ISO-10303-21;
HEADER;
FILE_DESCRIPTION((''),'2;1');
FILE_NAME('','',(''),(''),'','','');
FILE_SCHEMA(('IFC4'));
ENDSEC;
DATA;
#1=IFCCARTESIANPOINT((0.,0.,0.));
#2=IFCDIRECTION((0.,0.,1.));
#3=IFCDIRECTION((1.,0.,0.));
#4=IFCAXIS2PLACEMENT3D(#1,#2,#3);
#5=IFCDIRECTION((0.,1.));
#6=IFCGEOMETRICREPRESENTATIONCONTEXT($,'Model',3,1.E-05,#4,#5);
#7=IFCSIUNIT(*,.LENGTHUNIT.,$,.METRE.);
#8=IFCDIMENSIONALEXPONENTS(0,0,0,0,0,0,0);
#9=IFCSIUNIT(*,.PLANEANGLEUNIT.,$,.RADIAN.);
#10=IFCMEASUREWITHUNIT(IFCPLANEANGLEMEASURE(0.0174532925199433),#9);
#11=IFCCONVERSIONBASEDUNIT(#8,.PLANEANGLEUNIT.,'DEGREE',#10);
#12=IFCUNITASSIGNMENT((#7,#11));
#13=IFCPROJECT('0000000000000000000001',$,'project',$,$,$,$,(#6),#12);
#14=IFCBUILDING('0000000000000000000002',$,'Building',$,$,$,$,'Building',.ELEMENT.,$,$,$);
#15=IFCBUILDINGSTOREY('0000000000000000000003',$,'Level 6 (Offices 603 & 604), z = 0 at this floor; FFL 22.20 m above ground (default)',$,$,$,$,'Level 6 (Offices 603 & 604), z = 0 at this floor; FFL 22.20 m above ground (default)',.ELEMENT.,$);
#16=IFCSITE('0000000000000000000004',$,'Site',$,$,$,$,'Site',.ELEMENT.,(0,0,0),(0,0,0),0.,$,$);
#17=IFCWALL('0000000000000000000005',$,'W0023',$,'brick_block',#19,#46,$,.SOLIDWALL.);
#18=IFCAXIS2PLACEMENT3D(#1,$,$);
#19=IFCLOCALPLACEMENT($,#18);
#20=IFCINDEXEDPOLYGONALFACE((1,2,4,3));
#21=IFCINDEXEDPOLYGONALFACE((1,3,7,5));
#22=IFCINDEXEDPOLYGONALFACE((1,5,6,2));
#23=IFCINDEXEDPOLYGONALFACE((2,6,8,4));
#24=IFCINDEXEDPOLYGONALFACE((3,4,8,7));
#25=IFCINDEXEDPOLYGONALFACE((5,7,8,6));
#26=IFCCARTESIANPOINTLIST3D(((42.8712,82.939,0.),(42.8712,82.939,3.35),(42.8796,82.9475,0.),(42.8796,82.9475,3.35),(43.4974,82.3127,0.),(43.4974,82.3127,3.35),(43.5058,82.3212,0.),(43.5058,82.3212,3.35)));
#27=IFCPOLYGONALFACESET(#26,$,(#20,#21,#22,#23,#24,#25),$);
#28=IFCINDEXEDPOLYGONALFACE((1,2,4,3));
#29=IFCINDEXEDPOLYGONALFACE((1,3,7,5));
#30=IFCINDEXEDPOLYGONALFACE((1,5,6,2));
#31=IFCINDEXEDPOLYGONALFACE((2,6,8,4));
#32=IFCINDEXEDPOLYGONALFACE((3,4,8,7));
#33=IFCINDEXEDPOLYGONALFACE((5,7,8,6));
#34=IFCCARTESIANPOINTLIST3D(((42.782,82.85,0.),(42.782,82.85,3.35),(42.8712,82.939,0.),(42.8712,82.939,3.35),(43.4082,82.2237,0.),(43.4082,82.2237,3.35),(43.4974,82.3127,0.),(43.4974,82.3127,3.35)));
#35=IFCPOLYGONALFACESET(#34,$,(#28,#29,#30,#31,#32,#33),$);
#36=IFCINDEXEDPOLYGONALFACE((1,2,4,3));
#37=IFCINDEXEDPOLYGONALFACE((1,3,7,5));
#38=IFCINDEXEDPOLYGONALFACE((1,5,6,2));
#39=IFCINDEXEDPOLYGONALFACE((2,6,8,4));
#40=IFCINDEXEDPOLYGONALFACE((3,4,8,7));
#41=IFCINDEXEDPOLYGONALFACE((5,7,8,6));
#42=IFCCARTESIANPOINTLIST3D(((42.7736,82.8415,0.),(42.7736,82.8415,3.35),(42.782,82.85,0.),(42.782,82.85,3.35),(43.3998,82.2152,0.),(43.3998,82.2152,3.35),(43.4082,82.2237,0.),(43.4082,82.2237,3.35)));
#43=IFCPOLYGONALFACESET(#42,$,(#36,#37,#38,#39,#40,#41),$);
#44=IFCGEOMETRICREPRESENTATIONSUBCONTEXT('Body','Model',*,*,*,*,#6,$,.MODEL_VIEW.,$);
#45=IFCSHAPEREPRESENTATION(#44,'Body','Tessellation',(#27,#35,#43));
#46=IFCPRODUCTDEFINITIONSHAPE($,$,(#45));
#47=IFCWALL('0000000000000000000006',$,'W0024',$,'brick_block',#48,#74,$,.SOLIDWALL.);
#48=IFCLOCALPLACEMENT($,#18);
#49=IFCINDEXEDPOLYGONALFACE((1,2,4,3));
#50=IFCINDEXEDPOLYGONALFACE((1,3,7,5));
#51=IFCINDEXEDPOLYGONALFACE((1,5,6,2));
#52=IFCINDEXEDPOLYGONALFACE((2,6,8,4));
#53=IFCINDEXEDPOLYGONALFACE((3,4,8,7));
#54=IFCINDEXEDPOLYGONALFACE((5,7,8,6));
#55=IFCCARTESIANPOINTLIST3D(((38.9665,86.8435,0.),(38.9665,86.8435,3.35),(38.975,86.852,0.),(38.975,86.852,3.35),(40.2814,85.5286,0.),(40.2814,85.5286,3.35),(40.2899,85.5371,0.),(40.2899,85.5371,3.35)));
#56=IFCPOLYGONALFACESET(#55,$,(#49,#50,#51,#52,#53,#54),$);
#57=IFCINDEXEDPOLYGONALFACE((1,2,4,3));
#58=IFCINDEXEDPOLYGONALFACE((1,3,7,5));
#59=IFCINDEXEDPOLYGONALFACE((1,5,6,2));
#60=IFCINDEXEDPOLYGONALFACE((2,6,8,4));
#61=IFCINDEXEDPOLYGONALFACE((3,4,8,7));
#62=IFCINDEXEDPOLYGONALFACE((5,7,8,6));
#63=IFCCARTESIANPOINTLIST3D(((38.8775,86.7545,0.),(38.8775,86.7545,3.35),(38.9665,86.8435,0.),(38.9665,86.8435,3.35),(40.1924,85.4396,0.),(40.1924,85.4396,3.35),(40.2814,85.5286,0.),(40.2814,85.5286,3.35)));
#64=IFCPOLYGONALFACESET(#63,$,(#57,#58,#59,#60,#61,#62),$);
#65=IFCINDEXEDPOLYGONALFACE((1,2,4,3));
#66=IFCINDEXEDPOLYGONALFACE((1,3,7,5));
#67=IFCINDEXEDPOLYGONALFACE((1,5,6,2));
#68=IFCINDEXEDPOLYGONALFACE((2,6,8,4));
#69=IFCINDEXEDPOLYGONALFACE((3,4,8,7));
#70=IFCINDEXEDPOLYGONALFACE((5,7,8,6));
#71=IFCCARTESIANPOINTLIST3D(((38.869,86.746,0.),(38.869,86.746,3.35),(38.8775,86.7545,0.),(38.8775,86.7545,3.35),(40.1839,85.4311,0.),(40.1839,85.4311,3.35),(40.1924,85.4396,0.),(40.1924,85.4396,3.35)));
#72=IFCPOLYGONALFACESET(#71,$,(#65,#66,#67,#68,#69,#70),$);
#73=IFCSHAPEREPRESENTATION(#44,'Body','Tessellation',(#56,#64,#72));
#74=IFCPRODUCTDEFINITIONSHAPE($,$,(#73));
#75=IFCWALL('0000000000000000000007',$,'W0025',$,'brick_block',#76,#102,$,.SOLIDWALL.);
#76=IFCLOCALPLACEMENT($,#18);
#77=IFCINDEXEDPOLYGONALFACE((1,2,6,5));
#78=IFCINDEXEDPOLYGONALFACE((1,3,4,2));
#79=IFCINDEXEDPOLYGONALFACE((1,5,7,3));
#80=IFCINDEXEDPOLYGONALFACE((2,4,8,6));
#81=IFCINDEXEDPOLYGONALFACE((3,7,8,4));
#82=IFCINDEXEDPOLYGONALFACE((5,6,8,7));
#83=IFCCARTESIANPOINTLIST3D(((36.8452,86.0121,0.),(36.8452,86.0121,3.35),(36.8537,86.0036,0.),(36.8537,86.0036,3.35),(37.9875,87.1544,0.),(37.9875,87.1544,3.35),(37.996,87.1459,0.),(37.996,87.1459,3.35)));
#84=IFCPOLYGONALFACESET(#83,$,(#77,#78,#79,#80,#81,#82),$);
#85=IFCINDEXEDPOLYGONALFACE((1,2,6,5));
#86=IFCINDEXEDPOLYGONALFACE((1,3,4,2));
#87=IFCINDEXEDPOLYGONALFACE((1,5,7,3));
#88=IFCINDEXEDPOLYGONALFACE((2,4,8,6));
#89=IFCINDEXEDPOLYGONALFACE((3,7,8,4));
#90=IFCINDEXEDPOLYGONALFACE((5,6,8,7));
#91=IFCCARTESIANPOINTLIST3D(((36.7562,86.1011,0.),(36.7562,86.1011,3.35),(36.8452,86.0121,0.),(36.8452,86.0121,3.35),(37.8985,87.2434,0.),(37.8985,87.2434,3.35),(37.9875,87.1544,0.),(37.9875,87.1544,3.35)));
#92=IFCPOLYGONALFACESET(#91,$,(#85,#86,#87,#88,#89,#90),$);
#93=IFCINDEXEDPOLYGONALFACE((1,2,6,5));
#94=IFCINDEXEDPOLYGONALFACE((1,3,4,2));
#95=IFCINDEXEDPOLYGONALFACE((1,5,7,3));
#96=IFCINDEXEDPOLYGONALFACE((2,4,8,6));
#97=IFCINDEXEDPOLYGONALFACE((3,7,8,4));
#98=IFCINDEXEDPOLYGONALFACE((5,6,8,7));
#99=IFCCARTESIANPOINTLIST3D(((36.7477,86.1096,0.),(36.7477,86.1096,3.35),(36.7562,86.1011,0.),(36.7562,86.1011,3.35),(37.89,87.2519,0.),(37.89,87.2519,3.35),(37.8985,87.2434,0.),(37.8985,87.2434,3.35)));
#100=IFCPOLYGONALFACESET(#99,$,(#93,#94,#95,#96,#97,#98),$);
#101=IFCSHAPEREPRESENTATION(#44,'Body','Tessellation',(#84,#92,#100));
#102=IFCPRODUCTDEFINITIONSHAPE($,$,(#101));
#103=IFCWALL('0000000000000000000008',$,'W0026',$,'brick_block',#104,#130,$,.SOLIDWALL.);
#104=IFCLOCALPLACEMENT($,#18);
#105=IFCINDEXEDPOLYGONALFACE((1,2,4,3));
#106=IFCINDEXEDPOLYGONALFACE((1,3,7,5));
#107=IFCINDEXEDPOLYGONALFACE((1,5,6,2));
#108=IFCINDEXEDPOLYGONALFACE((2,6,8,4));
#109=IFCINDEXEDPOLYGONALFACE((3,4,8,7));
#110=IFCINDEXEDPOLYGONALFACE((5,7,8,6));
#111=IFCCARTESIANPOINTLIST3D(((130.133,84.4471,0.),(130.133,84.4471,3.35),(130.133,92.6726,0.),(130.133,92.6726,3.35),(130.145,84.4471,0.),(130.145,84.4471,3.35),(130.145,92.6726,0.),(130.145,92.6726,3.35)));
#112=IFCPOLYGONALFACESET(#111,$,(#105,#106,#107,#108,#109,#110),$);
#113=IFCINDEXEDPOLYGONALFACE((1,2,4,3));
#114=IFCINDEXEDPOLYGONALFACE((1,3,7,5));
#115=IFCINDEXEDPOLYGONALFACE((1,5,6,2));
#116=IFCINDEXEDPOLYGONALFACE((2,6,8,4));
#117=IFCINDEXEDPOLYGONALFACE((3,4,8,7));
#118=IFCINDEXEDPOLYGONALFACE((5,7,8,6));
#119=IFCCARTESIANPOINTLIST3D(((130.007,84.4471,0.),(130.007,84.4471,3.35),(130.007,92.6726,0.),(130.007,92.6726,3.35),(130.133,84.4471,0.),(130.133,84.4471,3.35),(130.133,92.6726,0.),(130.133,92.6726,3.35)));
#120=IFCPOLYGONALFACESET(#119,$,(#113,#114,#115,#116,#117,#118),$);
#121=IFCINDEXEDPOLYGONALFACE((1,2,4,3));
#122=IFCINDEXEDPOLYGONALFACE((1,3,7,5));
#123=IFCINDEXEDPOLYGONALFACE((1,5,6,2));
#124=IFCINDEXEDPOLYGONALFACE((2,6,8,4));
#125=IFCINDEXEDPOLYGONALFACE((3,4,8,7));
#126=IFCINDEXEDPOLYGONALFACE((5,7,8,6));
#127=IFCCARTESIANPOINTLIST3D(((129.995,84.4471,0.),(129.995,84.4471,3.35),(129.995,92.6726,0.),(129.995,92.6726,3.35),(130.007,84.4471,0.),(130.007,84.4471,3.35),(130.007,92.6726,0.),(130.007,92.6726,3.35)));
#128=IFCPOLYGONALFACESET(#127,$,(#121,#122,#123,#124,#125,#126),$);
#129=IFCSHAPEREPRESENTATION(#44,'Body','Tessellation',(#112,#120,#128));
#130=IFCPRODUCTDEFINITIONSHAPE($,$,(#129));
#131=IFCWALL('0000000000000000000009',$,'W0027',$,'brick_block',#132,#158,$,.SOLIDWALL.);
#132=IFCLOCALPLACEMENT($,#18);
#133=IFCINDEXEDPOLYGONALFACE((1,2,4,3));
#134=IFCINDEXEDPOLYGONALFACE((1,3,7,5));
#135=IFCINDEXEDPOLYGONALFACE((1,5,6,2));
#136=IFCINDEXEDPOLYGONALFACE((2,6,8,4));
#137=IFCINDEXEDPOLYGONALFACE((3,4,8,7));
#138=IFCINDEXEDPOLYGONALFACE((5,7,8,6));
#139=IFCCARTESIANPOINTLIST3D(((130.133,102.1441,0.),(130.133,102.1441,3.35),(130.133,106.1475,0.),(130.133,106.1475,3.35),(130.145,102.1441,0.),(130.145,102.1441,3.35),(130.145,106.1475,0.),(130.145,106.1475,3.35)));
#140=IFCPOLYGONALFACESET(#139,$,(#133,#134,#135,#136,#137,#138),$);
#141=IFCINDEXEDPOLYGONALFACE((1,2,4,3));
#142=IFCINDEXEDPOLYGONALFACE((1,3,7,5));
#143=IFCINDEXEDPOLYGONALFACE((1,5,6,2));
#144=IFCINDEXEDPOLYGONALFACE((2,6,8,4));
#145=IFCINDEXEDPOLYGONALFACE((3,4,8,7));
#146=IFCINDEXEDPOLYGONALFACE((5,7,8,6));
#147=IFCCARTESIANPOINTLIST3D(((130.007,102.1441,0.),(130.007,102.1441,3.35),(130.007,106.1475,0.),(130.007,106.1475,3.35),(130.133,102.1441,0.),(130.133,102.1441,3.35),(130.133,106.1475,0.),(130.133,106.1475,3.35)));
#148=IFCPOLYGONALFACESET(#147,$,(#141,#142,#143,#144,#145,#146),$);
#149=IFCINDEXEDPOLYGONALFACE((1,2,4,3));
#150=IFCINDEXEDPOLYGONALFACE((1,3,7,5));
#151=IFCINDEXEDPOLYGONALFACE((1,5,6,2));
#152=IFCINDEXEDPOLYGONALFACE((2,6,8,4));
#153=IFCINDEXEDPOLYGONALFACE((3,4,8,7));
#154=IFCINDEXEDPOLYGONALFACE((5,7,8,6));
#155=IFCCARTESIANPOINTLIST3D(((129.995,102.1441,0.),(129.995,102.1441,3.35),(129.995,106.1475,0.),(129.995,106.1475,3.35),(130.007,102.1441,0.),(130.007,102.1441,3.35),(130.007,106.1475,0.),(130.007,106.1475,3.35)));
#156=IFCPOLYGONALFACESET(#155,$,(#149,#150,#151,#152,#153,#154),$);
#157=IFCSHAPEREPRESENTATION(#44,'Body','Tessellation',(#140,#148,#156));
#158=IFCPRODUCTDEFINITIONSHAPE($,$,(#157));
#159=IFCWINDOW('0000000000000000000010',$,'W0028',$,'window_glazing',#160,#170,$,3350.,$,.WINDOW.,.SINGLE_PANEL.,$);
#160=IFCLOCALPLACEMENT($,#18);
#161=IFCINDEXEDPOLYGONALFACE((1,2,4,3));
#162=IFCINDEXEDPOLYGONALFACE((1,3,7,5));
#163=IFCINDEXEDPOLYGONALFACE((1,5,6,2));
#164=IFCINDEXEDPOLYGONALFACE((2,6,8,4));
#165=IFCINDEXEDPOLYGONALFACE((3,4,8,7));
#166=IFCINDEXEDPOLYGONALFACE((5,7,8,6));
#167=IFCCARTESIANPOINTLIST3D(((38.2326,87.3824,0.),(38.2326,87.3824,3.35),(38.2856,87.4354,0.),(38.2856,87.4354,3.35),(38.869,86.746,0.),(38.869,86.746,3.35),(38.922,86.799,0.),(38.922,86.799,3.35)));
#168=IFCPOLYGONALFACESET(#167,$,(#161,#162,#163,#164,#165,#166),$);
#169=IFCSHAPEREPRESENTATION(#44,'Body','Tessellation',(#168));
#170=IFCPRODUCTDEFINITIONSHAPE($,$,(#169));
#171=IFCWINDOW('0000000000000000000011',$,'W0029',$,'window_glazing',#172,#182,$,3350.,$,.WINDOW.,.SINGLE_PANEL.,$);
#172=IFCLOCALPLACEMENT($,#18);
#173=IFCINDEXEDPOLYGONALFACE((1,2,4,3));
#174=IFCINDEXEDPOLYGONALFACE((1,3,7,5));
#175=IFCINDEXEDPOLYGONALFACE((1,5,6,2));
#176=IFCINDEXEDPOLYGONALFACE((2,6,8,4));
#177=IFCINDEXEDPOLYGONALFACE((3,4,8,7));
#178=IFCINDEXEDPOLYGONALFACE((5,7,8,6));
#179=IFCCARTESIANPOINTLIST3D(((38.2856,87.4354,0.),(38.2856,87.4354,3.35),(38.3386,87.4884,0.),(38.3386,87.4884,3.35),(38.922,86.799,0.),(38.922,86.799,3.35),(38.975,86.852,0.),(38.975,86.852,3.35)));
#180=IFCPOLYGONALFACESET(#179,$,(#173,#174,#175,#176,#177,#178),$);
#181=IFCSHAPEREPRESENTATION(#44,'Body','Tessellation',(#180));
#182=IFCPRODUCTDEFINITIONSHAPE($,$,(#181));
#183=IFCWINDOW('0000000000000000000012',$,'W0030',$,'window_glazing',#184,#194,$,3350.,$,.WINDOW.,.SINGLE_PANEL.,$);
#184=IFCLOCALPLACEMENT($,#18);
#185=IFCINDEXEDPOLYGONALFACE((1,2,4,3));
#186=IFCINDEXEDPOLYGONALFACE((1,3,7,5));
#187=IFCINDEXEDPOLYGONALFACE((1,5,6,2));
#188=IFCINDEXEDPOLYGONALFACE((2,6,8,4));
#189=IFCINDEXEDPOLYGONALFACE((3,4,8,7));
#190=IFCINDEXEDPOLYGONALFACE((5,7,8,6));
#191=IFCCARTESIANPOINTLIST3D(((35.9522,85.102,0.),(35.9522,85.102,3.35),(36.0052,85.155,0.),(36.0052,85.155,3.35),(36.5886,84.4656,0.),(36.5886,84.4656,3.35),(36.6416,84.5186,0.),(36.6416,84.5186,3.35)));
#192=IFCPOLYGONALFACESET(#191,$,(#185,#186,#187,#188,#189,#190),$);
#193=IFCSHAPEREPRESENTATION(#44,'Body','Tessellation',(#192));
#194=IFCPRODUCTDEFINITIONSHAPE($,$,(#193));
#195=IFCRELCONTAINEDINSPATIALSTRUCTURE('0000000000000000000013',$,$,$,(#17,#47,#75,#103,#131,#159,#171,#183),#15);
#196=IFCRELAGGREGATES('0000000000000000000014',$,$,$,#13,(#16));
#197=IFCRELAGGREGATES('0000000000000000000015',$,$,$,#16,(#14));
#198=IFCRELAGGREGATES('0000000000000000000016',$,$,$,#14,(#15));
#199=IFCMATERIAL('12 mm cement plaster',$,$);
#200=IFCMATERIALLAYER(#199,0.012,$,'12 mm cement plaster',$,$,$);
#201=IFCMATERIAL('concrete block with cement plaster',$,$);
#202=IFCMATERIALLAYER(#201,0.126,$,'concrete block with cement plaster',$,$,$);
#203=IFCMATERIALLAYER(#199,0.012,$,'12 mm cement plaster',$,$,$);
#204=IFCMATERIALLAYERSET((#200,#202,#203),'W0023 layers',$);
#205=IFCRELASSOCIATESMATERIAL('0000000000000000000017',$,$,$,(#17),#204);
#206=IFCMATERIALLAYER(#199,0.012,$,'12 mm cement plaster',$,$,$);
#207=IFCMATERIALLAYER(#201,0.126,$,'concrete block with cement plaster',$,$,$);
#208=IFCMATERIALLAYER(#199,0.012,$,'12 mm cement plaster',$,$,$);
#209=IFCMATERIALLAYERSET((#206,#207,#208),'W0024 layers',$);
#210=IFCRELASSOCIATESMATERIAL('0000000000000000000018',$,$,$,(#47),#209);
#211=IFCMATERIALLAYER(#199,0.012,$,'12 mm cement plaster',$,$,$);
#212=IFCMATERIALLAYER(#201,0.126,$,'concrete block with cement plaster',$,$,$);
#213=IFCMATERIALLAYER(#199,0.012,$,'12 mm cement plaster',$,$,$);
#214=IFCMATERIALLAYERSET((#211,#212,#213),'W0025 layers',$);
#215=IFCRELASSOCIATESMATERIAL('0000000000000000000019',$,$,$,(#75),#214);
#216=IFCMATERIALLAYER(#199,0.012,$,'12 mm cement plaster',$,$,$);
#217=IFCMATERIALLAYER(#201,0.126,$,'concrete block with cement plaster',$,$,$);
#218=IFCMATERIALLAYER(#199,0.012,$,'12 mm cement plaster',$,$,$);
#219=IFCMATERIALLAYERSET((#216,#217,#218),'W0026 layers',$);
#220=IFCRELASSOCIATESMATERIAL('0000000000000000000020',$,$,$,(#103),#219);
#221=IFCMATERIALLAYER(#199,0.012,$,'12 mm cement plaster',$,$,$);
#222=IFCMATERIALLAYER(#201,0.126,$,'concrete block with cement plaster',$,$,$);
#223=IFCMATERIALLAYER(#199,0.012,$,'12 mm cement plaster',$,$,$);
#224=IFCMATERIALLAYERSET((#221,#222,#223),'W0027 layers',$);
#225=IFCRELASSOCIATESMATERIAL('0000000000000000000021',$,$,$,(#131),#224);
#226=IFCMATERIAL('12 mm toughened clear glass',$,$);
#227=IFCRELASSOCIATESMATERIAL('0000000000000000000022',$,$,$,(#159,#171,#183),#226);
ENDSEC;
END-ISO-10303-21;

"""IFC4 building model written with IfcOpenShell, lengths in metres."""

from ifc_helpers import new_model, entity, si_unit, converted_unit, direction, frame, frame_2d, origin_with_axes, place, context, subcontext, project, spatial, rectangle, extrude, material, layer, layer_set, layer_usage, element, save


model = new_model("IFC4")

# Units and contexts
model_context = context("Model", 3, precision=1e-05, world=origin_with_axes(), true_north=direction((0.0, 1.0)))
body_context = subcontext(model_context, "Body", "Model", "MODEL_VIEW")
ifc_project = project(units=[si_unit("LENGTHUNIT", "METRE"), converted_unit("PLANEANGLEUNIT", "DEGREE", entity("IfcPlaneAngleMeasure", 0.0174532925199433), si_unit("PLANEANGLEUNIT", "RADIAN"), dimensions=[0, 0, 0, 0, 0, 0, 0])], contexts=[model_context])

# Site, building, storey
site = spatial("IfcSite", under=ifc_project, Name="Site", LongName="Site", CompositionType="ELEMENT", RefLatitude=(0, 0, 0), RefLongitude=(0, 0, 0), RefElevation=0.0)
building = spatial("IfcBuilding", under=site, Name="Building", LongName="Building", CompositionType="ELEMENT")
storey = spatial("IfcBuildingStorey", under=building, Name="Level 6 (Offices 603 & 604), z = 0 at this floor; FFL 22.20 m above ground (default)", LongName="Level 6 (Offices 603 & 604), z = 0 at this floor; FFL 22.20 m above ground (default)", CompositionType="ELEMENT")

# Shared definitions
ifc_material_1 = material(Name="12 mm cement plaster")
ifc_material_2 = material(Name="concrete block with cement plaster")
placement = place(None, origin_with_axes())

# Shared definitions
ifc_material_3 = material(Name="12 mm toughened clear glass")

# Walls
ifc_layer_1 = layer(ifc_material_1, 0.012, Name="12 mm cement plaster")
ifc_layer_2 = layer(ifc_material_2, 0.126, Name="concrete block with cement plaster")
ifc_layer_3 = layer(ifc_material_1, 0.012, Name="12 mm cement plaster")
ifc_layer_set_1 = layer_set([ifc_layer_1, ifc_layer_2, ifc_layer_3], Name="W0023 layers")
ifc_layer_usage_1 = layer_usage(ifc_layer_set_1, "AXIS2", "POSITIVE", -0.075)
element("IfcWall", 1, at=placement, inside=storey, material=ifc_layer_usage_1, Name="W0023", ObjectType="brick_block", PredefinedType="SOLIDWALL", context=body_context, shape_type="SweptSolid", body=[
    extrude(rectangle(XDim=0.8857, YDim=0.012, at=frame_2d((0.0, 0.0), x_axis=(0.70705, -0.707163))), frame((43.1885, 82.6301, 0.0), z_axis=(0.0, 0.0, 1.0), x_axis=(1.0, 0.0, 0.0)), (0.0, 0.0, 1.0), 3.35),
    extrude(rectangle(XDim=0.8857, YDim=0.126, at=frame_2d((-0.0488, -0.0488), x_axis=(0.70705, -0.707163))), frame((43.1885, 82.6301, 0.0), z_axis=(0.0, 0.0, 1.0), x_axis=(1.0, 0.0, 0.0)), (0.0, 0.0, 1.0), 3.35),
    extrude(rectangle(XDim=0.8857, YDim=0.012, at=frame_2d((-0.0976, -0.0976), x_axis=(0.70705, -0.707163))), frame((43.1885, 82.6301, 0.0), z_axis=(0.0, 0.0, 1.0), x_axis=(1.0, 0.0, 0.0)), (0.0, 0.0, 1.0), 3.35),
])
ifc_layer_4 = layer(ifc_material_1, 0.012, Name="12 mm cement plaster")
ifc_layer_5 = layer(ifc_material_2, 0.126, Name="concrete block with cement plaster")
ifc_layer_6 = layer(ifc_material_1, 0.012, Name="12 mm cement plaster")
ifc_layer_set_2 = layer_set([ifc_layer_4, ifc_layer_5, ifc_layer_6], Name="W0024 layers")
ifc_layer_usage_2 = layer_usage(ifc_layer_set_2, "AXIS2", "POSITIVE", -0.075)
element("IfcWall", 2, at=placement, inside=storey, material=ifc_layer_usage_2, Name="W0024", ObjectType="brick_block", PredefinedType="SOLIDWALL", context=body_context, shape_type="SweptSolid", body=[
    extrude(rectangle(XDim=1.8595, YDim=0.012, at=frame_2d((0.0, 0.0), x_axis=(0.707107, -0.707107))), frame((39.6282, 86.1903, 0.0), z_axis=(0.0, 0.0, 1.0), x_axis=(1.0, 0.0, 0.0)), (0.0, 0.0, 1.0), 3.35),
    extrude(rectangle(XDim=1.8595, YDim=0.126, at=frame_2d((-0.0488, -0.0488), x_axis=(0.707107, -0.707107))), frame((39.6282, 86.1903, 0.0), z_axis=(0.0, 0.0, 1.0), x_axis=(1.0, 0.0, 0.0)), (0.0, 0.0, 1.0), 3.35),
    extrude(rectangle(XDim=1.8595, YDim=0.012, at=frame_2d((-0.0976, -0.0976), x_axis=(0.707107, -0.707107))), frame((39.6282, 86.1903, 0.0), z_axis=(0.0, 0.0, 1.0), x_axis=(1.0, 0.0, 0.0)), (0.0, 0.0, 1.0), 3.35),
])
ifc_layer_7 = layer(ifc_material_1, 0.012, Name="12 mm cement plaster")
ifc_layer_8 = layer(ifc_material_2, 0.126, Name="concrete block with cement plaster")
ifc_layer_9 = layer(ifc_material_1, 0.012, Name="12 mm cement plaster")
ifc_layer_set_3 = layer_set([ifc_layer_7, ifc_layer_8, ifc_layer_9], Name="W0025 layers")
ifc_layer_usage_3 = layer_usage(ifc_layer_set_3, "AXIS2", "POSITIVE", -0.075)
element("IfcWall", 3, at=placement, inside=storey, material=ifc_layer_usage_3, Name="W0025", ObjectType="brick_block", PredefinedType="SOLIDWALL", context=body_context, shape_type="SweptSolid", body=[
    extrude(rectangle(XDim=1.6155, YDim=0.012, at=frame_2d((0.0, 0.0), x_axis=(0.707107, 0.707107))), frame((37.4206, 86.579, 0.0), z_axis=(0.0, 0.0, 1.0), x_axis=(1.0, 0.0, 0.0)), (0.0, 0.0, 1.0), 3.35),
    extrude(rectangle(XDim=1.6155, YDim=0.126, at=frame_2d((-0.0488, 0.0488), x_axis=(0.707107, 0.707107))), frame((37.4206, 86.579, 0.0), z_axis=(0.0, 0.0, 1.0), x_axis=(1.0, 0.0, 0.0)), (0.0, 0.0, 1.0), 3.35),
    extrude(rectangle(XDim=1.6155, YDim=0.012, at=frame_2d((-0.0976, 0.0976), x_axis=(0.707107, 0.707107))), frame((37.4206, 86.579, 0.0), z_axis=(0.0, 0.0, 1.0), x_axis=(1.0, 0.0, 0.0)), (0.0, 0.0, 1.0), 3.35),
])
ifc_layer_10 = layer(ifc_material_1, 0.012, Name="12 mm cement plaster")
ifc_layer_11 = layer(ifc_material_2, 0.126, Name="concrete block with cement plaster")
ifc_layer_12 = layer(ifc_material_1, 0.012, Name="12 mm cement plaster")
ifc_layer_set_4 = layer_set([ifc_layer_10, ifc_layer_11, ifc_layer_12], Name="W0026 layers")
ifc_layer_usage_4 = layer_usage(ifc_layer_set_4, "AXIS2", "POSITIVE", -0.075)
element("IfcWall", 4, at=placement, inside=storey, material=ifc_layer_usage_4, Name="W0026", ObjectType="brick_block", PredefinedType="SOLIDWALL", context=body_context, shape_type="SweptSolid", body=[
    extrude(rectangle(XDim=8.2255, YDim=0.012, at=frame_2d((0.0, 0.0), x_axis=(0.0, 1.0))), frame((130.139, 88.5598, 0.0), z_axis=(0.0, 0.0, 1.0), x_axis=(1.0, 0.0, 0.0)), (0.0, 0.0, 1.0), 3.35),
    extrude(rectangle(XDim=8.2255, YDim=0.126, at=frame_2d((-0.069, 0.0), x_axis=(0.0, 1.0))), frame((130.139, 88.5598, 0.0), z_axis=(0.0, 0.0, 1.0), x_axis=(1.0, 0.0, 0.0)), (0.0, 0.0, 1.0), 3.35),
    extrude(rectangle(XDim=8.2255, YDim=0.012, at=frame_2d((-0.138, 0.0), x_axis=(0.0, 1.0))), frame((130.139, 88.5598, 0.0), z_axis=(0.0, 0.0, 1.0), x_axis=(1.0, 0.0, 0.0)), (0.0, 0.0, 1.0), 3.35),
])
ifc_layer_13 = layer(ifc_material_1, 0.012, Name="12 mm cement plaster")
ifc_layer_14 = layer(ifc_material_2, 0.126, Name="concrete block with cement plaster")
ifc_layer_15 = layer(ifc_material_1, 0.012, Name="12 mm cement plaster")
ifc_layer_set_5 = layer_set([ifc_layer_13, ifc_layer_14, ifc_layer_15], Name="W0027 layers")
ifc_layer_usage_5 = layer_usage(ifc_layer_set_5, "AXIS2", "POSITIVE", -0.075)
element("IfcWall", 5, at=placement, inside=storey, material=ifc_layer_usage_5, Name="W0027", ObjectType="brick_block", PredefinedType="SOLIDWALL", context=body_context, shape_type="SweptSolid", body=[
    extrude(rectangle(XDim=4.0034, YDim=0.012, at=frame_2d((0.0, 0.0), x_axis=(0.0, 1.0))), frame((130.139, 104.1458, 0.0), z_axis=(0.0, 0.0, 1.0), x_axis=(1.0, 0.0, 0.0)), (0.0, 0.0, 1.0), 3.35),
    extrude(rectangle(XDim=4.0034, YDim=0.126, at=frame_2d((-0.069, 0.0), x_axis=(0.0, 1.0))), frame((130.139, 104.1458, 0.0), z_axis=(0.0, 0.0, 1.0), x_axis=(1.0, 0.0, 0.0)), (0.0, 0.0, 1.0), 3.35),
    extrude(rectangle(XDim=4.0034, YDim=0.012, at=frame_2d((-0.138, 0.0), x_axis=(0.0, 1.0))), frame((130.139, 104.1458, 0.0), z_axis=(0.0, 0.0, 1.0), x_axis=(1.0, 0.0, 0.0)), (0.0, 0.0, 1.0), 3.35),
])

# Windows
element("IfcWindow", 6, at=placement, inside=storey, material=ifc_material_3, Name="W0028", ObjectType="window_glazing", OverallHeight=3350.0, PartitioningType="SINGLE_PANEL", PredefinedType="WINDOW", context=body_context, shape_type="SweptSolid", body=[
    extrude(rectangle(XDim=0.9, YDim=0.075, at=frame_2d((0.0, 0.0), x_axis=(0.707107, -0.707107))), frame((38.5773, 87.0907, 0.0), z_axis=(0.0, 0.0, 1.0), x_axis=(1.0, 0.0, 0.0)), (0.0, 0.0, 1.0), 3.35),
])
element("IfcWindow", 7, at=placement, inside=storey, material=ifc_material_3, Name="W0029", ObjectType="window_glazing", OverallHeight=3350.0, PartitioningType="SINGLE_PANEL", PredefinedType="WINDOW", context=body_context, shape_type="SweptSolid", body=[
    extrude(rectangle(XDim=0.9, YDim=0.075, at=frame_2d((0.0, 0.0), x_axis=(0.707107, -0.707107))), frame((38.6303, 87.1437, 0.0), z_axis=(0.0, 0.0, 1.0), x_axis=(1.0, 0.0, 0.0)), (0.0, 0.0, 1.0), 3.35),
])
element("IfcWindow", 8, at=placement, inside=storey, material=ifc_material_3, Name="W0030", ObjectType="window_glazing", OverallHeight=3350.0, PartitioningType="SINGLE_PANEL", PredefinedType="WINDOW", context=body_context, shape_type="SweptSolid", body=[
    extrude(rectangle(XDim=0.9, YDim=0.075, at=frame_2d((0.0, 0.0), x_axis=(0.707107, -0.707107))), frame((36.2969, 84.8103, 0.0), z_axis=(0.0, 0.0, 1.0), x_axis=(1.0, 0.0, 0.0)), (0.0, 0.0, 1.0), 3.35),
])

save(model, "model.ifc")
